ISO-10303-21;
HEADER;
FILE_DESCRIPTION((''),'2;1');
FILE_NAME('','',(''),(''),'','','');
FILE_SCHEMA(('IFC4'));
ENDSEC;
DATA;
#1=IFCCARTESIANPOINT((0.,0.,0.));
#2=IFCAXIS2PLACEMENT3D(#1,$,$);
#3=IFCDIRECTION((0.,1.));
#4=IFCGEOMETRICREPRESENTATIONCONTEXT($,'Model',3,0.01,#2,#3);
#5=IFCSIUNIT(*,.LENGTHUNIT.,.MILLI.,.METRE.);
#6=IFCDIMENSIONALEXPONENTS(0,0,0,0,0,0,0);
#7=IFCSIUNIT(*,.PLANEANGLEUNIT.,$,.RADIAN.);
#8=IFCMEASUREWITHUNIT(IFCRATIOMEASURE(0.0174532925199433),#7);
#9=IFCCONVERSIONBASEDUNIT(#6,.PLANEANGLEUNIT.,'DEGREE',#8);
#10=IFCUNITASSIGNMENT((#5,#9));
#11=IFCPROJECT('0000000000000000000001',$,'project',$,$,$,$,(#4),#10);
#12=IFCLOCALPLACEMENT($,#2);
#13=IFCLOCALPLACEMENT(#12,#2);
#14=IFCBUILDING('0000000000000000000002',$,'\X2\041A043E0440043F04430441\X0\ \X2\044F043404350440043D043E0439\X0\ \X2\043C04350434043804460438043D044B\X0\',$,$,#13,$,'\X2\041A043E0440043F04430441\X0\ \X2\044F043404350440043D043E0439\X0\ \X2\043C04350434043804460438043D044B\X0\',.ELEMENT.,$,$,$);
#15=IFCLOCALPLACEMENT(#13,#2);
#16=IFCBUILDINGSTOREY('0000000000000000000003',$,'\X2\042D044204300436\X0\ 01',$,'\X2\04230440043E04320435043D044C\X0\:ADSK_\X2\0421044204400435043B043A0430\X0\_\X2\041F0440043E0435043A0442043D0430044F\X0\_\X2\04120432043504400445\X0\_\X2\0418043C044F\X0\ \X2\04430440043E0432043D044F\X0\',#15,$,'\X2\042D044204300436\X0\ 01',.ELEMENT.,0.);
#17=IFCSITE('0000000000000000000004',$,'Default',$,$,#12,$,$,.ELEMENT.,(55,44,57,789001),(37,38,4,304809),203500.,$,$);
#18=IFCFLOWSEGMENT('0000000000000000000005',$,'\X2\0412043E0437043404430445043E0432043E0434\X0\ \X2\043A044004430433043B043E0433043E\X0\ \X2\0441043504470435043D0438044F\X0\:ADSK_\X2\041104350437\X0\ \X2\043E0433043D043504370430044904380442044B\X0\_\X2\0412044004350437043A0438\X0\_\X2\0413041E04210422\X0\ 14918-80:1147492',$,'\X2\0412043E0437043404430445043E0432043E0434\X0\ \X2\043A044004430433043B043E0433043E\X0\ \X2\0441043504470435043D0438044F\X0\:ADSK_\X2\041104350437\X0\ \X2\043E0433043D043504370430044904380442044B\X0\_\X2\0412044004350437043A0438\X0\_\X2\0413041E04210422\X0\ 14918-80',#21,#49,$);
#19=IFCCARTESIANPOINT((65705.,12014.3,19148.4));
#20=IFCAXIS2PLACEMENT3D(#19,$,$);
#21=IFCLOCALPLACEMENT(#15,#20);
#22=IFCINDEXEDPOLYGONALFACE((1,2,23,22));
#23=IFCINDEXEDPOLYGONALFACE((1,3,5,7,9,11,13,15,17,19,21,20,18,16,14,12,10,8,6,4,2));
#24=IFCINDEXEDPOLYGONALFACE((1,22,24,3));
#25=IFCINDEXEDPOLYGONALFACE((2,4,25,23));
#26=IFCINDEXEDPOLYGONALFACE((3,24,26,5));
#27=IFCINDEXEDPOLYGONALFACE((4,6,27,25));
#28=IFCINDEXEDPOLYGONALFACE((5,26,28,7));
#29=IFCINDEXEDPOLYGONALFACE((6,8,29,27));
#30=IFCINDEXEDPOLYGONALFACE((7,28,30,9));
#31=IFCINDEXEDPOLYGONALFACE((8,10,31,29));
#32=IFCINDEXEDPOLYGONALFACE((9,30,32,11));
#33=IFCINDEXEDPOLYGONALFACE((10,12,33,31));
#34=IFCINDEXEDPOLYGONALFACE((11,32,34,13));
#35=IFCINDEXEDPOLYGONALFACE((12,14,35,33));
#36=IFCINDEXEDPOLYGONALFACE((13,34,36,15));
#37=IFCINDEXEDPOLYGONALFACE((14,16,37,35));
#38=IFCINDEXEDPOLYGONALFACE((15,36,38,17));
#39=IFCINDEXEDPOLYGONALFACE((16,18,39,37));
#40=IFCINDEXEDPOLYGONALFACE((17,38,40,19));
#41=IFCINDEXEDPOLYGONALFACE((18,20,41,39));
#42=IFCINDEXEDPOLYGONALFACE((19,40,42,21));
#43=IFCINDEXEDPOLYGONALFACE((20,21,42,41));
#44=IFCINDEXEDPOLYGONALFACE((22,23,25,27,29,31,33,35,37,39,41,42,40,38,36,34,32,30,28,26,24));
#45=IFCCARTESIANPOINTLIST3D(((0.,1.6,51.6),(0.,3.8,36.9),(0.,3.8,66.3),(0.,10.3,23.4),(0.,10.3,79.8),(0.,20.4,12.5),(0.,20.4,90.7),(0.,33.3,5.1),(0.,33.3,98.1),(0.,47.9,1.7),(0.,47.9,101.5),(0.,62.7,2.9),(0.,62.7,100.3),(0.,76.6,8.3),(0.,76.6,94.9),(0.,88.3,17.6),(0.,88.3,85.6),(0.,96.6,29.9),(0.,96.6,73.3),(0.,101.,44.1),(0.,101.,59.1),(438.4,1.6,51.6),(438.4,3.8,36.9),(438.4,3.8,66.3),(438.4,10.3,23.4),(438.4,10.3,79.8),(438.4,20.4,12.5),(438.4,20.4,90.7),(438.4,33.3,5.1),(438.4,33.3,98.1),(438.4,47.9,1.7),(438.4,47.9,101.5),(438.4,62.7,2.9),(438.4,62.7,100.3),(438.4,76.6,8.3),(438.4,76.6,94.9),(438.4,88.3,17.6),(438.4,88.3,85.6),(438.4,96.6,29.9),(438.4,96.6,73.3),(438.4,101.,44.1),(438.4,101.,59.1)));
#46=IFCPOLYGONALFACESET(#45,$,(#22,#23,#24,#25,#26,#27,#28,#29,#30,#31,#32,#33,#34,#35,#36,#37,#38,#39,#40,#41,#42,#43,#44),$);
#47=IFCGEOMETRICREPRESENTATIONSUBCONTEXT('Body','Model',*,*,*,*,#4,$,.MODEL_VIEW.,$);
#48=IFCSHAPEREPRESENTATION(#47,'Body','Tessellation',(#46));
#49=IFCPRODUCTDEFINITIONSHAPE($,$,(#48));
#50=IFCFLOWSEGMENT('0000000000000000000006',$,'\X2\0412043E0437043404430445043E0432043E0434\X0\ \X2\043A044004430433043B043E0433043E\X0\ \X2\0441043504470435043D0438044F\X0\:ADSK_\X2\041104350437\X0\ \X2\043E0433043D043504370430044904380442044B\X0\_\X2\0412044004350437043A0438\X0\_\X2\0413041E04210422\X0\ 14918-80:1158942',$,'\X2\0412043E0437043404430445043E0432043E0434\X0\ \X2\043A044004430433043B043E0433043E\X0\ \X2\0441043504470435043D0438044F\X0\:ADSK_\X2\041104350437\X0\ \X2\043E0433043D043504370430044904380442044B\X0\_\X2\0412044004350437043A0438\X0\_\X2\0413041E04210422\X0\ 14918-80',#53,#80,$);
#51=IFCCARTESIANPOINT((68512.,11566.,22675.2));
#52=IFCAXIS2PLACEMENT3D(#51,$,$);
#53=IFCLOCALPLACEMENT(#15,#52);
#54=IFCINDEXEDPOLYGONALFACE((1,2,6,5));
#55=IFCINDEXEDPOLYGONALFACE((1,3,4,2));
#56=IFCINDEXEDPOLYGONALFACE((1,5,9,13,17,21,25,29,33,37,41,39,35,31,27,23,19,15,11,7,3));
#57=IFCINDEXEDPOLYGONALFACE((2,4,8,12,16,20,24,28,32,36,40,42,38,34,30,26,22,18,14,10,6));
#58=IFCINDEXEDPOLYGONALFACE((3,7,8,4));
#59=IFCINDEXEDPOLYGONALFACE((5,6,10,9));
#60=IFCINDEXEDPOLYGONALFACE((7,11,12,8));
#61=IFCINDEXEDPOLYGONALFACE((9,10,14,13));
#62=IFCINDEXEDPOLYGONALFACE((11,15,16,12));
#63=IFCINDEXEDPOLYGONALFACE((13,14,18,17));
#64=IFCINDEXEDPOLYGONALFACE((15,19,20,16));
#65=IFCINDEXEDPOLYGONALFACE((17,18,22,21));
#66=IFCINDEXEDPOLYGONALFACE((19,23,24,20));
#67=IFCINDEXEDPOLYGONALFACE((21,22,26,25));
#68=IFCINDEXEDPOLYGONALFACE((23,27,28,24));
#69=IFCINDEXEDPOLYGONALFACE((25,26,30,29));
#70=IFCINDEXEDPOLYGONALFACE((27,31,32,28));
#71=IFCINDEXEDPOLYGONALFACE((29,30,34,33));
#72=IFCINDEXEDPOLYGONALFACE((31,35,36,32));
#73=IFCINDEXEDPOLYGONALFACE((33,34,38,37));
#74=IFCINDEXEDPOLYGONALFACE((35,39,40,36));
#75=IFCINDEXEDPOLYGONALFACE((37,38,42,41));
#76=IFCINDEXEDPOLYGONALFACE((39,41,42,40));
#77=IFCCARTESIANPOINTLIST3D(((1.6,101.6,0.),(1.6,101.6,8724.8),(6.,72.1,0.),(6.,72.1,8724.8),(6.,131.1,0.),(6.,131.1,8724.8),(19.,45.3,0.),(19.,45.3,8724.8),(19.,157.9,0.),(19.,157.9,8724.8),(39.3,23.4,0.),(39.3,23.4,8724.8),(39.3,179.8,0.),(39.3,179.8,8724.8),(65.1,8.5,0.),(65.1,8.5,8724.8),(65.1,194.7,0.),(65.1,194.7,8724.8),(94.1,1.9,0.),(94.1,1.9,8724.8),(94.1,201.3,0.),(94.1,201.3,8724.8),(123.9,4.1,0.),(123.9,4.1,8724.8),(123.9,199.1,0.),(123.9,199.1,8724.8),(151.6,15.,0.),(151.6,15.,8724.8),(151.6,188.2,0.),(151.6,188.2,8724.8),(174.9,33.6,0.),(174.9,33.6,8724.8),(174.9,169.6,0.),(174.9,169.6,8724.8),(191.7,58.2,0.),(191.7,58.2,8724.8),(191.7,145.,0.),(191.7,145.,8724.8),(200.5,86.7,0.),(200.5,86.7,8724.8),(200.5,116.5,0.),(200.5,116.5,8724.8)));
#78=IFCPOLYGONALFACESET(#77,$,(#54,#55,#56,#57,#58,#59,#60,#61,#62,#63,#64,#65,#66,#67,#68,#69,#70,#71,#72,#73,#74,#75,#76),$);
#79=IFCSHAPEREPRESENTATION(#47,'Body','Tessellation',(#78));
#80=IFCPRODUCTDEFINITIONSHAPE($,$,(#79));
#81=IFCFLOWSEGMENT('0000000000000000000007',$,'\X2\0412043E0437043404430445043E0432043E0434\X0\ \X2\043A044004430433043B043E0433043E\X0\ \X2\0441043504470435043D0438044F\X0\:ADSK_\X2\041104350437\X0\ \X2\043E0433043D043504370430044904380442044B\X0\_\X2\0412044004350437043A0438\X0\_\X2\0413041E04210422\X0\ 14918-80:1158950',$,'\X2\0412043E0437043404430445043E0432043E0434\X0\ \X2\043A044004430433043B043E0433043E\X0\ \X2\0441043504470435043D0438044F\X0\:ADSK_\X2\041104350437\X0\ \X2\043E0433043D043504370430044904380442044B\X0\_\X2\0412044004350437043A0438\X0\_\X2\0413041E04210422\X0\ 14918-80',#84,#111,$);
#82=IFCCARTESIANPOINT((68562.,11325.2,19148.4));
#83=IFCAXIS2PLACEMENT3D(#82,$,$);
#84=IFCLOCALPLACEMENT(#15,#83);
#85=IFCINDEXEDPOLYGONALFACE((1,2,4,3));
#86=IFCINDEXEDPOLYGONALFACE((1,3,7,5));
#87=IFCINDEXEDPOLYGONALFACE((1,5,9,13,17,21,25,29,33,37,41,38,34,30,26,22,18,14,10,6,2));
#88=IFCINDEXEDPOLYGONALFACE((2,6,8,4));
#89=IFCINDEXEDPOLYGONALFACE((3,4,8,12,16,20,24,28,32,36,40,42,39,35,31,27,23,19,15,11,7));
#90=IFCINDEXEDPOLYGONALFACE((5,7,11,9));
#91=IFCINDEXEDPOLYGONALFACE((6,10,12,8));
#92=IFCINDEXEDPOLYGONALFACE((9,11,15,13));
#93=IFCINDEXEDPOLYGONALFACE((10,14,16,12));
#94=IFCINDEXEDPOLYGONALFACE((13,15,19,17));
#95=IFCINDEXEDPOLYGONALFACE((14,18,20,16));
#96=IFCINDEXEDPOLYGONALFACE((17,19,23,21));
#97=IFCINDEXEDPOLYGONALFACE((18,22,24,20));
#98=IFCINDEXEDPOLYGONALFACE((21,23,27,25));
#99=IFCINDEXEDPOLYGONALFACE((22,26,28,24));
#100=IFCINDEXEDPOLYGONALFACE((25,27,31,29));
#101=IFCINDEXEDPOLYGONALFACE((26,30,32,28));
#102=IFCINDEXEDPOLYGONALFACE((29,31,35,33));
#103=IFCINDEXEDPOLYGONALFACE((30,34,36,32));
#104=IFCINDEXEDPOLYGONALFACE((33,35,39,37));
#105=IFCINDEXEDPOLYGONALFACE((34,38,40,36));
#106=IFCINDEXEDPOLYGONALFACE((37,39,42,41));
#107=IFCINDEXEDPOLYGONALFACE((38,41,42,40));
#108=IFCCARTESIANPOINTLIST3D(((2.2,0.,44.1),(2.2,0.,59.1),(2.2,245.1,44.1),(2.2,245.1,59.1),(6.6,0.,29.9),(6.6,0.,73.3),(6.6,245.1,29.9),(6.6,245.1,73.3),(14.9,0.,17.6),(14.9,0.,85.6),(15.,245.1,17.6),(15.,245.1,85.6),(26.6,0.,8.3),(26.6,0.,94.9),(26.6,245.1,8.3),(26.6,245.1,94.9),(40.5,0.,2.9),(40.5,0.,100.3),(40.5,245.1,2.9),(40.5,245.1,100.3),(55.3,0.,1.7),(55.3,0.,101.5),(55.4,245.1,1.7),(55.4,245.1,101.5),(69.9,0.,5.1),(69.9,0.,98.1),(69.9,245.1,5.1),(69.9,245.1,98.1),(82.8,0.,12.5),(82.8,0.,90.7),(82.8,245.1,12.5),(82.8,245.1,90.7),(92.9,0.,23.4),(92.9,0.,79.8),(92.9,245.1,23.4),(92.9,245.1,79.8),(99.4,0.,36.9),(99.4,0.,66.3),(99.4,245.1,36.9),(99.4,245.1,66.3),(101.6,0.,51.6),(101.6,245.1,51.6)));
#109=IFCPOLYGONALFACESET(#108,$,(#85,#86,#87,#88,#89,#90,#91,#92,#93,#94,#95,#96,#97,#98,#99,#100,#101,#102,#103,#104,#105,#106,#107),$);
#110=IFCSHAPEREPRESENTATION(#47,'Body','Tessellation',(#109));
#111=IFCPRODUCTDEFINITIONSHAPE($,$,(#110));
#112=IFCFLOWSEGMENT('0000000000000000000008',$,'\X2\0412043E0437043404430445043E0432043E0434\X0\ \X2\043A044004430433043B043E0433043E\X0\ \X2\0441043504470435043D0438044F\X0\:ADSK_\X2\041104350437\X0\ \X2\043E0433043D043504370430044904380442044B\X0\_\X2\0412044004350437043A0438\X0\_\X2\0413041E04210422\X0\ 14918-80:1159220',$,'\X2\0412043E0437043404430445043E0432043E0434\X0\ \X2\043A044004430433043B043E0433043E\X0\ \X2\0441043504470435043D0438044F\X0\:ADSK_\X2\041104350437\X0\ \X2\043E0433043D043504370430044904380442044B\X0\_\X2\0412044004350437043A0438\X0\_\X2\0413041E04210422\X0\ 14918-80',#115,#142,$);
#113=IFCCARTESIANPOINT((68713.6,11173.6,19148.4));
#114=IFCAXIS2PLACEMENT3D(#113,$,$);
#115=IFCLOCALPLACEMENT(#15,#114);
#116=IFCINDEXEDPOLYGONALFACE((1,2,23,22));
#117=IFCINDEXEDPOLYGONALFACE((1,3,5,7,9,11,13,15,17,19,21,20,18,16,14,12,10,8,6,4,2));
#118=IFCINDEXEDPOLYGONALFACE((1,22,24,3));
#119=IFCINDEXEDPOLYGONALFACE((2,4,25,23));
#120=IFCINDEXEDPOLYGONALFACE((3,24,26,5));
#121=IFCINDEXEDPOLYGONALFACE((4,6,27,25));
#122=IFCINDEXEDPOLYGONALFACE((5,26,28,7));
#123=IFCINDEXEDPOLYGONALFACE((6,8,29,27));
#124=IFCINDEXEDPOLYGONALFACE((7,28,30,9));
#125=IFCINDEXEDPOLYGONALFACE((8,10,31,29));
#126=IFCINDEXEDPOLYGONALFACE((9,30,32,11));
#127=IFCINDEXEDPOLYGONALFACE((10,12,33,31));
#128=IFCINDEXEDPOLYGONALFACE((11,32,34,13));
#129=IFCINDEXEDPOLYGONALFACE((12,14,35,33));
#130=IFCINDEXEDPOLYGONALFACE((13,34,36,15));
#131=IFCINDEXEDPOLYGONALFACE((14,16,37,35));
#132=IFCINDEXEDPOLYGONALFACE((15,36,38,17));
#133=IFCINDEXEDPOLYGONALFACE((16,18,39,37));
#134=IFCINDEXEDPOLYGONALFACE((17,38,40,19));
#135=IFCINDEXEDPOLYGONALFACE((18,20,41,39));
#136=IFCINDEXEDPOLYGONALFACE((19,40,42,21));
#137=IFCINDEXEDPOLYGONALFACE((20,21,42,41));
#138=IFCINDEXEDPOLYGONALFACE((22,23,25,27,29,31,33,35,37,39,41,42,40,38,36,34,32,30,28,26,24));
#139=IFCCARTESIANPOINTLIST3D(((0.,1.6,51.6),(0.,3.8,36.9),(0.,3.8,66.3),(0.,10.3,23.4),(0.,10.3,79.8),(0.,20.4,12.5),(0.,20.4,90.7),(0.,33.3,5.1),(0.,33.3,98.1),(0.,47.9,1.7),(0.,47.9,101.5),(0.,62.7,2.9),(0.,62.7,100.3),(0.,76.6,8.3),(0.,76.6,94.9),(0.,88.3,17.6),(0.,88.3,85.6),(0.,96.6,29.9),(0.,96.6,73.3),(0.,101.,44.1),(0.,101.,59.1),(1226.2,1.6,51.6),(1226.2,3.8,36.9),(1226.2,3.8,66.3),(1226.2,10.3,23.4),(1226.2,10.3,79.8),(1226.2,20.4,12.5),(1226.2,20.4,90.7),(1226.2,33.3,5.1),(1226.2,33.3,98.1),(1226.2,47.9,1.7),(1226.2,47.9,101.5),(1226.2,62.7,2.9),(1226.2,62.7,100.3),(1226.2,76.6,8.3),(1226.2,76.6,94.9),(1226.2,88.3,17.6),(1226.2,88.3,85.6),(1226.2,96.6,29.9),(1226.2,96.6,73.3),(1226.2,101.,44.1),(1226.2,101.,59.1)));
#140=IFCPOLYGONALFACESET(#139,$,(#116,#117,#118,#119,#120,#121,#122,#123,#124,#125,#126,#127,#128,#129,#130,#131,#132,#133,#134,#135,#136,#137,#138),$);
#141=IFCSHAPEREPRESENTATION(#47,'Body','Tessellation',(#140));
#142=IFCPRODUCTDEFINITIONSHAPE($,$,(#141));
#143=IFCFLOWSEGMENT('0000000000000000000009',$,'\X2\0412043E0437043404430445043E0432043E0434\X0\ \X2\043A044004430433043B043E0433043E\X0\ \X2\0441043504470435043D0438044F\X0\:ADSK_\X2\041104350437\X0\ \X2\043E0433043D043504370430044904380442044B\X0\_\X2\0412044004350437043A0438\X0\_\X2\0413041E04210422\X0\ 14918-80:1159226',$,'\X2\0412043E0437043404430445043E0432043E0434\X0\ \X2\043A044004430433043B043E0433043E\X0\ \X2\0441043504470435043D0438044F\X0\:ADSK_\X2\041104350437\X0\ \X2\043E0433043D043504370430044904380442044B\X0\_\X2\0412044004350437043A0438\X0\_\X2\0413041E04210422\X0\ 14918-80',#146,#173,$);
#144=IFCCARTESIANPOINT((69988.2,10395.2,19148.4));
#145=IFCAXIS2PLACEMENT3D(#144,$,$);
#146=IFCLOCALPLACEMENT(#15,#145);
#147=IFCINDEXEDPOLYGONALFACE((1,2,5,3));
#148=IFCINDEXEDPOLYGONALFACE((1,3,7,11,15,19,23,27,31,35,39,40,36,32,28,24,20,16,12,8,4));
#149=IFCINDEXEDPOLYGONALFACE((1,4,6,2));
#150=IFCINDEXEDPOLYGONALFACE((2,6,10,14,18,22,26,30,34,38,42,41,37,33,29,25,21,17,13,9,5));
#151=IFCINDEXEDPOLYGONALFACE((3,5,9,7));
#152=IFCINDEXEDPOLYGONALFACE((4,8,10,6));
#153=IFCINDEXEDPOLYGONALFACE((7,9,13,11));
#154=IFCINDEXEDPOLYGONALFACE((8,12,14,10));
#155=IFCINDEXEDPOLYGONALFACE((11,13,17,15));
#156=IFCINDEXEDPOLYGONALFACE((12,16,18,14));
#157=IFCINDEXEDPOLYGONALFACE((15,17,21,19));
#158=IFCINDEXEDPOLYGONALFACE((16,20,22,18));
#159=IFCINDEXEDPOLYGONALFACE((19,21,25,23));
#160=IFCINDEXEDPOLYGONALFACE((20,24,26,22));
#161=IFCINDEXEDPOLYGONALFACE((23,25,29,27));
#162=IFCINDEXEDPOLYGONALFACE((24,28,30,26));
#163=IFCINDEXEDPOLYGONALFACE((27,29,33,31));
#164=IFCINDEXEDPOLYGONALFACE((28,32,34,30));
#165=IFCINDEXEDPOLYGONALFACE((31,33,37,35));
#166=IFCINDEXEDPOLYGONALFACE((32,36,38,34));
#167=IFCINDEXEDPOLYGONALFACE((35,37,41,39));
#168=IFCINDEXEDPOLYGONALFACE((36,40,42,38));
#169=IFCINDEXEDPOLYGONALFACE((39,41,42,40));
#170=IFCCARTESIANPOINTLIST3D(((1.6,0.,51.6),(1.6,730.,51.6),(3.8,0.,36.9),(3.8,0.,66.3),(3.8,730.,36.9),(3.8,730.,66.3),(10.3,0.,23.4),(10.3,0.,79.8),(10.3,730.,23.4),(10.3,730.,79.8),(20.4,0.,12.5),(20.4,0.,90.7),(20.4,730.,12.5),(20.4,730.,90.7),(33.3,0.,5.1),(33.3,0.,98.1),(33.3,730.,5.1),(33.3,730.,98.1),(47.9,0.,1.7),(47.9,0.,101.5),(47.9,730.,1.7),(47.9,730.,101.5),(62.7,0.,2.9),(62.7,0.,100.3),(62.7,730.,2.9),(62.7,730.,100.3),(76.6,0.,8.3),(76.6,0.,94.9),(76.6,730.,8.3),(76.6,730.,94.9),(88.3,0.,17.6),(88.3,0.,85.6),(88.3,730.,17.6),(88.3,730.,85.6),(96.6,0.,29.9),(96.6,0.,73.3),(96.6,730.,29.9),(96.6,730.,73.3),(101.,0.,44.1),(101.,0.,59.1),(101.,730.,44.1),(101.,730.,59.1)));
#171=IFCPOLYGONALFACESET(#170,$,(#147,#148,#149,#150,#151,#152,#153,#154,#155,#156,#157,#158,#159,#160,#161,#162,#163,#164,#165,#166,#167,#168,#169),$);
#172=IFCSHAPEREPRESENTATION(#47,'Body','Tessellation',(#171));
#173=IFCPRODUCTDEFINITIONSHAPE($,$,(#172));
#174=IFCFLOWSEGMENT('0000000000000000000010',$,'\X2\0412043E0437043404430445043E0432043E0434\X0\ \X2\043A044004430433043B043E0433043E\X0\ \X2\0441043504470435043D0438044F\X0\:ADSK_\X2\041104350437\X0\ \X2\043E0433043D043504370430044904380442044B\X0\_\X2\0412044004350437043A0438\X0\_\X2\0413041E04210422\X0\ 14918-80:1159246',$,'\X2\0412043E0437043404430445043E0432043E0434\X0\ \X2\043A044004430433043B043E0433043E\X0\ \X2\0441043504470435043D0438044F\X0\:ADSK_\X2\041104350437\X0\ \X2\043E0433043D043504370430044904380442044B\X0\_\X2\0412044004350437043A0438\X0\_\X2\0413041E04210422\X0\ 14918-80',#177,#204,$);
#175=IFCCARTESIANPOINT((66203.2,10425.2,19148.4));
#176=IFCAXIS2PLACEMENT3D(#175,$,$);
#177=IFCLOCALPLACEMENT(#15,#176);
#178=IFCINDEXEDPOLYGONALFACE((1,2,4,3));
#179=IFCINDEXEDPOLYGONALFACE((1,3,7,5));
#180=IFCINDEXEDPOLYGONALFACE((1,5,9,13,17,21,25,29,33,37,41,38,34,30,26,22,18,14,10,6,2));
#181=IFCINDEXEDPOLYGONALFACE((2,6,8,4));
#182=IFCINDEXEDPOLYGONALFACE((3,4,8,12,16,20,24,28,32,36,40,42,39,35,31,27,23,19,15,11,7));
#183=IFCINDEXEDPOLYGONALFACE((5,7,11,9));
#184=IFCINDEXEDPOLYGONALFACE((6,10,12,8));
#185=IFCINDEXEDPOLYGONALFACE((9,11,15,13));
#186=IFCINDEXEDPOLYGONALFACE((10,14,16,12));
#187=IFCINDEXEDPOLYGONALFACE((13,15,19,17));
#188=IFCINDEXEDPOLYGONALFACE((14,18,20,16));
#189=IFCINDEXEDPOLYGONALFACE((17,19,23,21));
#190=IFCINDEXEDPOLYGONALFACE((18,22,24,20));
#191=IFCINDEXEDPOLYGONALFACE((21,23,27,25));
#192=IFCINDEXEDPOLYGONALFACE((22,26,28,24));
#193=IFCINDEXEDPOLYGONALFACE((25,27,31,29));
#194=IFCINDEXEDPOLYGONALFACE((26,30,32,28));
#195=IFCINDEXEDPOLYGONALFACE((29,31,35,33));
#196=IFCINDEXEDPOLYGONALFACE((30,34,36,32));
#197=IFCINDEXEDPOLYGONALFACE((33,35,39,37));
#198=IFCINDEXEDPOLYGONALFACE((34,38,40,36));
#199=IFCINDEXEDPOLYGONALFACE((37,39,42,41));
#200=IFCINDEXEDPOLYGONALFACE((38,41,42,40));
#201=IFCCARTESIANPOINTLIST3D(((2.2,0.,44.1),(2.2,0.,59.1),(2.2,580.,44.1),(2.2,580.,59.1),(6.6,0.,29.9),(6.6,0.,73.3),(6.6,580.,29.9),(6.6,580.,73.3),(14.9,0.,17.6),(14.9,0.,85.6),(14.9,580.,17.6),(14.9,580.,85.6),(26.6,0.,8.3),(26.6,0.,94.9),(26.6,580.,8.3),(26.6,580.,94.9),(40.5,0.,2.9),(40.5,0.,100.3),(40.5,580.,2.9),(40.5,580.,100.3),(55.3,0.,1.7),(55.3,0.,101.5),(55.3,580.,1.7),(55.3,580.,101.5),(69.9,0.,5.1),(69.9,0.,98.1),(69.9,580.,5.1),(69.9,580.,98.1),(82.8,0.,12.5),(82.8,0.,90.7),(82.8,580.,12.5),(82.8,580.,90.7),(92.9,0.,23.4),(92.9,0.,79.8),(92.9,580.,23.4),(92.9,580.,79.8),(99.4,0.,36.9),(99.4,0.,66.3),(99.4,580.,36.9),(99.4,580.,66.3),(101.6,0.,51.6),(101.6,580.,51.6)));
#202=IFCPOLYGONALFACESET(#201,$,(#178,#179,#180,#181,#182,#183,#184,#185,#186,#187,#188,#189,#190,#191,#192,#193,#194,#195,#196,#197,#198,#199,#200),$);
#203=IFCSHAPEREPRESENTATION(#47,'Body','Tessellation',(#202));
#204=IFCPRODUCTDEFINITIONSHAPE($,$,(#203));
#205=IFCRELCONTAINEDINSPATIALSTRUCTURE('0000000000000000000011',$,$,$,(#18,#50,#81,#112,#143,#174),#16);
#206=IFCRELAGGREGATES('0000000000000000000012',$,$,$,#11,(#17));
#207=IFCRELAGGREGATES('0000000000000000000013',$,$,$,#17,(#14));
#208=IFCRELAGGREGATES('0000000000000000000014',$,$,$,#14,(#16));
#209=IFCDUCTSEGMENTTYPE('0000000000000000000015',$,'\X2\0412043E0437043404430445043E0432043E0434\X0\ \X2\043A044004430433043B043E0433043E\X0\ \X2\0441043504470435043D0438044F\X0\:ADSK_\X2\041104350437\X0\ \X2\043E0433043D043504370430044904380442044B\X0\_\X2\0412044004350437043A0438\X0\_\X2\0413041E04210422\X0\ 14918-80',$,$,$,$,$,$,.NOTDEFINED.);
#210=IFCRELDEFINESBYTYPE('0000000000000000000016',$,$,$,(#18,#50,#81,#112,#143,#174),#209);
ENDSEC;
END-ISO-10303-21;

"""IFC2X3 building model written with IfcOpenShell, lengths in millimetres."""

from ifc_helpers import new_model, entity, si_unit, converted_unit, direction, frame, origin, origin_2d_with_axis, place, context, subcontext, project, spatial, circle, extrude, type_object, element, save


model = new_model("IFC2X3")

# Units and contexts
model_context = context("Model", 3, precision=0.01, world=origin(), true_north=direction((0.0, 1.0)))
body_context = subcontext(model_context, "Body", "Model", "MODEL_VIEW")
ifc_project = project(units=[si_unit("LENGTHUNIT", "METRE", prefix="MILLI"), converted_unit("PLANEANGLEUNIT", "DEGREE", entity("IfcRatioMeasure", 0.0174532925199433), si_unit("PLANEANGLEUNIT", "RADIAN"), dimensions=[0, 0, 0, 0, 0, 0, 0])], contexts=[model_context])

# Site, building, storey
site_placement = place(None, origin())
site = spatial("IfcSite", under=ifc_project, at=site_placement, Name="Default", CompositionType="ELEMENT", RefLatitude=(55, 44, 57, 789001), RefLongitude=(37, 38, 4, 304809), RefElevation=203500.0)
building_placement = place(site_placement, origin())
building = spatial("IfcBuilding", under=site, at=building_placement, Name="Корпус ядерной медицины", LongName="Корпус ядерной медицины", CompositionType="ELEMENT")
storey_placement = place(building_placement, origin())
storey = spatial("IfcBuildingStorey", under=building, at=storey_placement, Name="Этаж 01", ObjectType="Уровень:ADSK_Стрелка_Проектная_Вверх_Имя уровня", LongName="Этаж 01", CompositionType="ELEMENT", Elevation=0.0)

# Flow segments
duct_segment_type_1 = type_object("IfcDuctSegmentType", Name="Воздуховод круглого сечения:ADSK_Без огнезащиты_Врезки_ГОСТ 14918-80", PredefinedType="NOTDEFINED")
flow_segment_1_placement = place(storey_placement, frame((65705.0, 12014.3, 19148.4)))
element("IfcFlowSegment", 1, at=flow_segment_1_placement, inside=storey, type_object=duct_segment_type_1, Name="Воздуховод круглого сечения:ADSK_Без огнезащиты_Врезки_ГОСТ 14918-80:1147492", ObjectType="Воздуховод круглого сечения:ADSK_Без огнезащиты_Врезки_ГОСТ 14918-80", context=body_context, shape_type="SweptSolid", body=[
    extrude(circle(Radius=50.0, at=origin_2d_with_axis()), frame((0.0, 51.6, 51.6), z_axis=(1.0, 0.0, 0.0), x_axis=(0.0, -1.0, 0.0)), (0.0, 0.0, 1.0), 438.4),
])
flow_segment_2_placement = place(storey_placement, frame((68512.0, 11566.0, 22675.2)))
element("IfcFlowSegment", 2, at=flow_segment_2_placement, inside=storey, type_object=duct_segment_type_1, Name="Воздуховод круглого сечения:ADSK_Без огнезащиты_Врезки_ГОСТ 14918-80:1158942", ObjectType="Воздуховод круглого сечения:ADSK_Без огнезащиты_Врезки_ГОСТ 14918-80", context=body_context, shape_type="SweptSolid", body=[
    extrude(circle(Radius=100.0, at=origin_2d_with_axis()), frame((101.6, 101.6, 0.0), z_axis=(0.0, 0.0, 1.0), x_axis=(-1.0, 0.0, 0.0)), (0.0, 0.0, 1.0), 8724.8),
])
flow_segment_3_placement = place(storey_placement, frame((68562.0, 11325.2, 19148.4)))
element("IfcFlowSegment", 3, at=flow_segment_3_placement, inside=storey, type_object=duct_segment_type_1, Name="Воздуховод круглого сечения:ADSK_Без огнезащиты_Врезки_ГОСТ 14918-80:1158950", ObjectType="Воздуховод круглого сечения:ADSK_Без огнезащиты_Врезки_ГОСТ 14918-80", context=body_context, shape_type="SweptSolid", body=[
    extrude(circle(Radius=50.0, at=origin_2d_with_axis()), frame((51.6, 0.0, 51.6), z_axis=(0.000117, 1.0, 0.0), x_axis=(1.0, -0.000117, 0.0)), (0.0, 0.0, 1.0), 245.1),
])
flow_segment_4_placement = place(storey_placement, frame((68713.6, 11173.6, 19148.4)))
element("IfcFlowSegment", 4, at=flow_segment_4_placement, inside=storey, type_object=duct_segment_type_1, Name="Воздуховод круглого сечения:ADSK_Без огнезащиты_Врезки_ГОСТ 14918-80:1159220", ObjectType="Воздуховод круглого сечения:ADSK_Без огнезащиты_Врезки_ГОСТ 14918-80", context=body_context, shape_type="SweptSolid", body=[
    extrude(circle(Radius=50.0, at=origin_2d_with_axis()), frame((0.0, 51.6, 51.6), z_axis=(1.0, 0.0, 0.0), x_axis=(0.0, -1.0, 0.0)), (0.0, 0.0, 1.0), 1226.2),
])
flow_segment_5_placement = place(storey_placement, frame((69988.2, 10395.2, 19148.4)))
element("IfcFlowSegment", 5, at=flow_segment_5_placement, inside=storey, type_object=duct_segment_type_1, Name="Воздуховод круглого сечения:ADSK_Без огнезащиты_Врезки_ГОСТ 14918-80:1159226", ObjectType="Воздуховод круглого сечения:ADSK_Без огнезащиты_Врезки_ГОСТ 14918-80", context=body_context, shape_type="SweptSolid", body=[
    extrude(circle(Radius=50.0, at=origin_2d_with_axis()), frame((51.6, 0.0, 51.6), z_axis=(0.0, 1.0, 0.0), x_axis=(-1.0, 0.0, 0.0)), (0.0, 0.0, 1.0), 730.0),
])
flow_segment_6_placement = place(storey_placement, frame((66203.2, 10425.2, 19148.4)))
element("IfcFlowSegment", 6, at=flow_segment_6_placement, inside=storey, type_object=duct_segment_type_1, Name="Воздуховод круглого сечения:ADSK_Без огнезащиты_Врезки_ГОСТ 14918-80:1159246", ObjectType="Воздуховод круглого сечения:ADSK_Без огнезащиты_Врезки_ГОСТ 14918-80", context=body_context, shape_type="SweptSolid", body=[
    extrude(circle(Radius=50.0, at=origin_2d_with_axis()), frame((51.6, 0.0, 51.6), z_axis=(0.0, 1.0, 0.0), x_axis=(1.0, 0.0, 0.0)), (0.0, 0.0, 1.0), 580.0),
])

save(model, "model.ifc")
